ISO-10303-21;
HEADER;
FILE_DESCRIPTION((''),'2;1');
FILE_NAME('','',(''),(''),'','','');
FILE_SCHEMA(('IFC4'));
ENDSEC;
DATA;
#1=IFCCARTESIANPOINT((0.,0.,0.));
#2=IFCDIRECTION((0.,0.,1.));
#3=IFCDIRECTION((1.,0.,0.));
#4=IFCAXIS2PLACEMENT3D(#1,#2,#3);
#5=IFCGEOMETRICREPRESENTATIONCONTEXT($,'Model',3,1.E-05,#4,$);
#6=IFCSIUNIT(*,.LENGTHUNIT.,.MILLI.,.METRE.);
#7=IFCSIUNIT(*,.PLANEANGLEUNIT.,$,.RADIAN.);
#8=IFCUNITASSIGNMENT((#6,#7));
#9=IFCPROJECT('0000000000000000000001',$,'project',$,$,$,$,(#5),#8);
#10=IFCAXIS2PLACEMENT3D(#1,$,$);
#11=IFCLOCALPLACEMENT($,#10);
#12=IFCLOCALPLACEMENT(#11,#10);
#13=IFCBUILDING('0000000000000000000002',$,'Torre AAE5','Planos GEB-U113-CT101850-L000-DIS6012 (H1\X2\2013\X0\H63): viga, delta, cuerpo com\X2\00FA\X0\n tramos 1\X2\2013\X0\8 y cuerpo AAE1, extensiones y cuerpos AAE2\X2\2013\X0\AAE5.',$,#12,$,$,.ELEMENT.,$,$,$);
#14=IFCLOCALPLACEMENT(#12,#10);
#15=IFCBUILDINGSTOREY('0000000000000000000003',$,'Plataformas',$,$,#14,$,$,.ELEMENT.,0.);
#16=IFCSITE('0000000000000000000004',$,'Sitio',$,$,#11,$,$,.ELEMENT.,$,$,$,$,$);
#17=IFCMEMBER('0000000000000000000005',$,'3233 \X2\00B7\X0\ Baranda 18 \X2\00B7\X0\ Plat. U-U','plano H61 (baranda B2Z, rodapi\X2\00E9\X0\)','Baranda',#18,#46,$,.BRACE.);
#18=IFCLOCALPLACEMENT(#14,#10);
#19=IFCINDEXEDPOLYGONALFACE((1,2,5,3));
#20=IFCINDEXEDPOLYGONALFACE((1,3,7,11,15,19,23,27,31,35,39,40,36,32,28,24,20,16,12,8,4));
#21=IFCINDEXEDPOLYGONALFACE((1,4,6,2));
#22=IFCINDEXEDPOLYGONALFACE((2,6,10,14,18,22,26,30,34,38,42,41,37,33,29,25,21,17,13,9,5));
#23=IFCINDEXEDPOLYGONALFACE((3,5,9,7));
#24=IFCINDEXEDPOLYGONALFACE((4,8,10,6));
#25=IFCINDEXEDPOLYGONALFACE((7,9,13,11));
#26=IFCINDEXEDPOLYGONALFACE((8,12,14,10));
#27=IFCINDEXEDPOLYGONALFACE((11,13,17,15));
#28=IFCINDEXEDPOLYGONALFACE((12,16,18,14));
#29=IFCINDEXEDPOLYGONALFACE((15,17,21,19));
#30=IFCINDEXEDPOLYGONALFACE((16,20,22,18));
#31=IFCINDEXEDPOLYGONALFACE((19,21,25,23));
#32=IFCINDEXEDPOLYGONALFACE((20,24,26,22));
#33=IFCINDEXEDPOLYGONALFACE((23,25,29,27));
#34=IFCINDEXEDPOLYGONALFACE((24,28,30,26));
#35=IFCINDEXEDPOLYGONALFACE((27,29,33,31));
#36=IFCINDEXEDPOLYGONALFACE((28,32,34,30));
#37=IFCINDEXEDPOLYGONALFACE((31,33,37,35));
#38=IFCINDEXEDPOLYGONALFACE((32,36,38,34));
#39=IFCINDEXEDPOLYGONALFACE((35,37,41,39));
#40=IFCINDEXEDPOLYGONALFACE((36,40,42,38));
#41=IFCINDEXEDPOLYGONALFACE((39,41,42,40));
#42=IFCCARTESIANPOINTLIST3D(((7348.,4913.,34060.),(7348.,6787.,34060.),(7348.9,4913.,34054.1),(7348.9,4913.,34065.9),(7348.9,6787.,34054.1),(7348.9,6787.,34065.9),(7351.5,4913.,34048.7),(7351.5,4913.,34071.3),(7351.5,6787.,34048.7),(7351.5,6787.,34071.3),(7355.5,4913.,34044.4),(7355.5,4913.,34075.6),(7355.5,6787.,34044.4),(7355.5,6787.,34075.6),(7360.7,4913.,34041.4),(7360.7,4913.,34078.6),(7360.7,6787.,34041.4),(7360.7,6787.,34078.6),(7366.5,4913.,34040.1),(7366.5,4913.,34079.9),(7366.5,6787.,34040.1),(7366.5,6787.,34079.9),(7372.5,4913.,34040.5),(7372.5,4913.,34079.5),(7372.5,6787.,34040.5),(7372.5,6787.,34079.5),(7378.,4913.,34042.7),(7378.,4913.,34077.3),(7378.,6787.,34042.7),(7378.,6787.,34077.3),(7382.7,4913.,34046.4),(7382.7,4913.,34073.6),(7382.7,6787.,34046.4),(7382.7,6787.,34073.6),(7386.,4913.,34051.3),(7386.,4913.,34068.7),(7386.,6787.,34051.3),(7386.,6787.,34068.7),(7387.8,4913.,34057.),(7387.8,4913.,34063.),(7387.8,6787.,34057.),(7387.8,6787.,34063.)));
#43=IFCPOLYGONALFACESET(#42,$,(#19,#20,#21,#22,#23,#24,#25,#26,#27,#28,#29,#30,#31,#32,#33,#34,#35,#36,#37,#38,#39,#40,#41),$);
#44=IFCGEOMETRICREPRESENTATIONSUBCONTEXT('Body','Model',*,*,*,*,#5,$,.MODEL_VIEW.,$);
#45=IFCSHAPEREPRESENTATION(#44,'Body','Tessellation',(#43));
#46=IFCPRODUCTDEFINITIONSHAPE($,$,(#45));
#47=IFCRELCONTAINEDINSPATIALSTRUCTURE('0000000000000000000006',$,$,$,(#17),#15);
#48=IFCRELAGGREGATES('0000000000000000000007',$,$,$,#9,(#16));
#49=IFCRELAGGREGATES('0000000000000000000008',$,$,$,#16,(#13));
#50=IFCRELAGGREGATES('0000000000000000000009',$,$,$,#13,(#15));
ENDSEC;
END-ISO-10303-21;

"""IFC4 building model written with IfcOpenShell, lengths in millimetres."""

from ifc_helpers import new_model, si_unit, frame, origin, origin_with_axes, place, context, subcontext, project, spatial, circle, extrude, element, save


model = new_model("IFC4")

# Units and contexts
model_context = context("Model", 3, precision=1e-05, world=origin_with_axes())
body_context = subcontext(model_context, "Body", "Model", "MODEL_VIEW")
ifc_project = project(units=[si_unit("LENGTHUNIT", "METRE", prefix="MILLI"), si_unit("PLANEANGLEUNIT", "RADIAN")], contexts=[model_context])

# Site, building, storey
site_placement = place(None, origin())
site = spatial("IfcSite", under=ifc_project, at=site_placement, Name="Sitio", CompositionType="ELEMENT")
building_placement = place(site_placement, origin())
building = spatial("IfcBuilding", under=site, at=building_placement, Name="Torre AAE5", Description="Planos GEB-U113-CT101850-L000-DIS6012 (H1–H63): viga, delta, cuerpo común tramos 1–8 y cuerpo AAE1, extensiones y cuerpos AAE2–AAE5.", CompositionType="ELEMENT")
storey_placement = place(building_placement, origin())
storey = spatial("IfcBuildingStorey", under=building, at=storey_placement, Name="Plataformas", CompositionType="ELEMENT", Elevation=0.0)

# Member
member_1_placement = place(storey_placement, frame((7368.0, 4913.0, 34060.0), z_axis=(0.0, 1.0, 0.0), x_axis=(-1.0, 0.0, 0.0)))
element("IfcMember", 1, at=member_1_placement, inside=storey, Name="3233 · Baranda 18 · Plat. U-U", Description="plano H61 (baranda B2Z, rodapié)", ObjectType="Baranda", PredefinedType="BRACE", context=body_context, shape_type="SweptSolid", body=[
    extrude(circle(Radius=20.0), None, (0.0, 0.0, 1.0), 1874.0),
])

save(model, "model.ifc")
